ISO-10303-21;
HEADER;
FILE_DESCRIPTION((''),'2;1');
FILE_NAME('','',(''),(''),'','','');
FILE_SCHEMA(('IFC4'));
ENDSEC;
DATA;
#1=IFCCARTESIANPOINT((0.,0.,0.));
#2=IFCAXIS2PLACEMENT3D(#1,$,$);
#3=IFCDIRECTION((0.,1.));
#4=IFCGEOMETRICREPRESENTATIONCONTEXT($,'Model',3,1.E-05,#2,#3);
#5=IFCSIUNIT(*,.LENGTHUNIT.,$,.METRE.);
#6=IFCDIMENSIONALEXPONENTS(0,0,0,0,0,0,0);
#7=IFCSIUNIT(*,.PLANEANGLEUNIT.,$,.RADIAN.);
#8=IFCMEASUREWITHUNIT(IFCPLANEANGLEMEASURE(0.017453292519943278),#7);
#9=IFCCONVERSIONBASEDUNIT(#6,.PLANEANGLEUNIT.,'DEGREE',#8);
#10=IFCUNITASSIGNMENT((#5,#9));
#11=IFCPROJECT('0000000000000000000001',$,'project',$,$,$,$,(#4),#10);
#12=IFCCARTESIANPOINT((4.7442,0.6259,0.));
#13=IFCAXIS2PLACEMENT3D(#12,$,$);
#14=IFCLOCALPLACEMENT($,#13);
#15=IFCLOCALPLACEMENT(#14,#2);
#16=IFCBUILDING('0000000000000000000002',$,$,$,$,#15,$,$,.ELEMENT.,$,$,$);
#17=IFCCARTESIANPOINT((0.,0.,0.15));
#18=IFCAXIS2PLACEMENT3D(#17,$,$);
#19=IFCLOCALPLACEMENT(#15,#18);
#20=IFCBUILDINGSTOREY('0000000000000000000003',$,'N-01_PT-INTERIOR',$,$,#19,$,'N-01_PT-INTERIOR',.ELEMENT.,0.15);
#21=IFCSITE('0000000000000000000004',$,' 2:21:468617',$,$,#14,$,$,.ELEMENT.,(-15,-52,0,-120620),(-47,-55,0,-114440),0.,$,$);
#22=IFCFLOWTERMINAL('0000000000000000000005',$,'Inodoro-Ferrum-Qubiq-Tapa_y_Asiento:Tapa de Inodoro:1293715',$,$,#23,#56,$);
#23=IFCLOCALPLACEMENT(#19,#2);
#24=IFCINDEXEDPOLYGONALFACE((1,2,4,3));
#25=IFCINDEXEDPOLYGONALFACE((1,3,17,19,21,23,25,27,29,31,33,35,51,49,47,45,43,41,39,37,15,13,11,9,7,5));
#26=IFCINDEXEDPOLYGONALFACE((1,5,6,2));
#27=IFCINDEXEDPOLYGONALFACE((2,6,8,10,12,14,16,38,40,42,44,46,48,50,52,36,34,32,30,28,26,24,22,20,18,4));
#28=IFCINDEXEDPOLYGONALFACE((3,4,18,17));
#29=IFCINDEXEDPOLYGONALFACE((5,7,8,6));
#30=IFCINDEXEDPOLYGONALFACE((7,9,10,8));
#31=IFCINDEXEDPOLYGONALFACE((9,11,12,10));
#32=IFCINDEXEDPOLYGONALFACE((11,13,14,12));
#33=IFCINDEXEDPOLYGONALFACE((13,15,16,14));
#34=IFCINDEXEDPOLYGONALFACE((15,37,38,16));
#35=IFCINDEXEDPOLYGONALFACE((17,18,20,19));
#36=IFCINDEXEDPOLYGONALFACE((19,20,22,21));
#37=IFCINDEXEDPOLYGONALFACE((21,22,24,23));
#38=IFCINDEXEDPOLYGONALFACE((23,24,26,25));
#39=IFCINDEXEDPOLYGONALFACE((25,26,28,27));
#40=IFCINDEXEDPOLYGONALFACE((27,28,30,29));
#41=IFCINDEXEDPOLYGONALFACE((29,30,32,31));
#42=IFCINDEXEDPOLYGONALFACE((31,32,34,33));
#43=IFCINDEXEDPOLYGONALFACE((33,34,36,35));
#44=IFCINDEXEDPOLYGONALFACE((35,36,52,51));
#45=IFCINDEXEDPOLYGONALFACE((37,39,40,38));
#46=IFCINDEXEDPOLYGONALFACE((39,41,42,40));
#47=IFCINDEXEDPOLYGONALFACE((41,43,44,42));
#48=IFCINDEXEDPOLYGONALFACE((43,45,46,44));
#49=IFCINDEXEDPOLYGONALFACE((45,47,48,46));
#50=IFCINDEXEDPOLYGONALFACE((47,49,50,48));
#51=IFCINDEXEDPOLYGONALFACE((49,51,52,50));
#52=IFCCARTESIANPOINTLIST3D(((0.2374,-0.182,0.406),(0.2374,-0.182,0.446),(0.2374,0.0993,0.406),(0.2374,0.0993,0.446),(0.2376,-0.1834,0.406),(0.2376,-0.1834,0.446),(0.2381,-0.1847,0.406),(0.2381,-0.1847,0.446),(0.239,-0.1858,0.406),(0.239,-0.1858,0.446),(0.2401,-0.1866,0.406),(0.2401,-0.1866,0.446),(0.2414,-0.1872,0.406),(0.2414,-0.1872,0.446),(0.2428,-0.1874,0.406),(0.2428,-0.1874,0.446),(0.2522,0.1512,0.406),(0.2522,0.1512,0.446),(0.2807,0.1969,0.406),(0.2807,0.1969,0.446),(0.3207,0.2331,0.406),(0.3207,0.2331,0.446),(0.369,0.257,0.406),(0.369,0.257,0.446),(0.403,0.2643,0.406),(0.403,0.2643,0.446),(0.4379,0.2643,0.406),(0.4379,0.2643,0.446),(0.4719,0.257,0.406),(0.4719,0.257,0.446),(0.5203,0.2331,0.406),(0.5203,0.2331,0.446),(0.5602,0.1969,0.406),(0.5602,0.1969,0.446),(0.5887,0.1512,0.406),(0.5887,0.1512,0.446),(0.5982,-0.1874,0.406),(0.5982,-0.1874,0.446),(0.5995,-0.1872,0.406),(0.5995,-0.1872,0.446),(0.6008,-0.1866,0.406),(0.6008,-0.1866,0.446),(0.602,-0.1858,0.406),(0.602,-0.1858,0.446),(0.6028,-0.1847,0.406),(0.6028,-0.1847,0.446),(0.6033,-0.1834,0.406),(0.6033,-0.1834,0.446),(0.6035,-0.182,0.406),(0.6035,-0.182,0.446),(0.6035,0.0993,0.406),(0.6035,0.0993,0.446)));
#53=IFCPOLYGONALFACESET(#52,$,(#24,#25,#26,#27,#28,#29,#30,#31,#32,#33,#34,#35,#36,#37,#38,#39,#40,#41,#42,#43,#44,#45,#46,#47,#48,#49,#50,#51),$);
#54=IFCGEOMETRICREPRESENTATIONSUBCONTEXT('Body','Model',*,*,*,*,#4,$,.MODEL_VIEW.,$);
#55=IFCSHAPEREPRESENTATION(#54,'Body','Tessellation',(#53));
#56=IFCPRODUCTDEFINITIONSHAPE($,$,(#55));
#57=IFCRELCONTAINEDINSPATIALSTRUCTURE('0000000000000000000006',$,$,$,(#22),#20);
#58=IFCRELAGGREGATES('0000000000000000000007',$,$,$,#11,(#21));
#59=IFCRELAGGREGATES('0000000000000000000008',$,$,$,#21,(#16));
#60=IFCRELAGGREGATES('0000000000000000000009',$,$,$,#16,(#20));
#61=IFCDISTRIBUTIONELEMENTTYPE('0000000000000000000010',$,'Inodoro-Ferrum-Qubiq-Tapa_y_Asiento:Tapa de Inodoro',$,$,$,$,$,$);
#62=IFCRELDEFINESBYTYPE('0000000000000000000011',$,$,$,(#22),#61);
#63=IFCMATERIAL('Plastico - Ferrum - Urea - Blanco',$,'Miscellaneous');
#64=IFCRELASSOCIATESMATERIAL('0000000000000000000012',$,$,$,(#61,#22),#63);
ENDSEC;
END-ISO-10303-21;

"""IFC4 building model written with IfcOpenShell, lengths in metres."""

from ifc_helpers import new_model, entity, si_unit, converted_unit, direction, frame, origin, place, context, subcontext, project, spatial, line, arc, indexed_curve, outline, extrude, source, transform, mapped, material, type_object, type_shapes, element, save


model = new_model("IFC4")

# Units and contexts
model_context = context("Model", 3, precision=1e-05, world=origin(), true_north=direction((0.0, 1.0)))
body_context = subcontext(model_context, "Body", "Model", "MODEL_VIEW")
ifc_project = project(units=[si_unit("LENGTHUNIT", "METRE"), converted_unit("PLANEANGLEUNIT", "DEGREE", entity("IfcPlaneAngleMeasure", 0.017453292519943278), si_unit("PLANEANGLEUNIT", "RADIAN"), dimensions=[0, 0, 0, 0, 0, 0, 0])], contexts=[model_context])

# Site, building, storey
site_placement = place(None, frame((4.7442, 0.6259, 0.0)))
site = spatial("IfcSite", under=ifc_project, at=site_placement, Name=" 2:21:468617", CompositionType="ELEMENT", RefLatitude=(-15, -52, 0, -120620), RefLongitude=(-47, -55, 0, -114440), RefElevation=0.0)
building_placement = place(site_placement, origin())
building = spatial("IfcBuilding", under=site, at=building_placement, CompositionType="ELEMENT")
storey_placement = place(building_placement, frame((0.0, 0.0, 0.15)))
storey = spatial("IfcBuildingStorey", under=building, at=storey_placement, Name="N-01_PT-INTERIOR", LongName="N-01_PT-INTERIOR", CompositionType="ELEMENT", Elevation=0.15)

# Flow terminal
ifc_material_1 = material(Name="Plastico - Ferrum - Urea - Blanco", Category="Miscellaneous")
distribution_element_type = type_object("IfcDistributionElementType", Name="Inodoro-Ferrum-Qubiq-Tapa_y_Asiento:Tapa de Inodoro", material=ifc_material_1)
shared_shape = source(origin(), body_context, "Body", "SweptSolid", [
    extrude(outline(indexed_curve([(-0.1787, -0.1831), (0.1026, -0.1831), (0.2002, -0.1397), (0.2602, -0.0514), (0.2685, 0.0), (0.2602, 0.0514), (0.2002, 0.1397), (0.1026, 0.1831), (-0.1787, 0.1831), (-0.1825, 0.1815), (-0.1841, 0.1777), (-0.1841, -0.1777), (-0.1825, -0.1815)], segments=[line(1, 2), arc(2, 3, 4), arc(4, 5, 6), arc(6, 7, 8), line(8, 9), arc(9, 10, 11), line(11, 12), arc(12, 13, 1)], self_intersect=False)), frame((0.0, -0.4295, 0.0), z_axis=(0.0, 0.0, 1.0), x_axis=(0.0, -1.0, 0.0)), (0.0, 0.0, 1.0), 0.04),
])
type_shapes(distribution_element_type, [shared_shape])
flow_terminal_placement = place(storey_placement, frame((0.4205, -0.4328, 0.406), z_axis=(0.0, 0.0, 1.0), x_axis=(-1.0, 0.0, 0.0)))
element("IfcFlowTerminal", 1, at=flow_terminal_placement, inside=storey, type_object=distribution_element_type, material=ifc_material_1, Name="Inodoro-Ferrum-Qubiq-Tapa_y_Asiento:Tapa de Inodoro:1293715", context=body_context, shape_type="MappedRepresentation", body=[
    mapped(shared_shape, transform((0.0, 0.0, 0.0), scale=1.0)),
])

save(model, "model.ifc")
